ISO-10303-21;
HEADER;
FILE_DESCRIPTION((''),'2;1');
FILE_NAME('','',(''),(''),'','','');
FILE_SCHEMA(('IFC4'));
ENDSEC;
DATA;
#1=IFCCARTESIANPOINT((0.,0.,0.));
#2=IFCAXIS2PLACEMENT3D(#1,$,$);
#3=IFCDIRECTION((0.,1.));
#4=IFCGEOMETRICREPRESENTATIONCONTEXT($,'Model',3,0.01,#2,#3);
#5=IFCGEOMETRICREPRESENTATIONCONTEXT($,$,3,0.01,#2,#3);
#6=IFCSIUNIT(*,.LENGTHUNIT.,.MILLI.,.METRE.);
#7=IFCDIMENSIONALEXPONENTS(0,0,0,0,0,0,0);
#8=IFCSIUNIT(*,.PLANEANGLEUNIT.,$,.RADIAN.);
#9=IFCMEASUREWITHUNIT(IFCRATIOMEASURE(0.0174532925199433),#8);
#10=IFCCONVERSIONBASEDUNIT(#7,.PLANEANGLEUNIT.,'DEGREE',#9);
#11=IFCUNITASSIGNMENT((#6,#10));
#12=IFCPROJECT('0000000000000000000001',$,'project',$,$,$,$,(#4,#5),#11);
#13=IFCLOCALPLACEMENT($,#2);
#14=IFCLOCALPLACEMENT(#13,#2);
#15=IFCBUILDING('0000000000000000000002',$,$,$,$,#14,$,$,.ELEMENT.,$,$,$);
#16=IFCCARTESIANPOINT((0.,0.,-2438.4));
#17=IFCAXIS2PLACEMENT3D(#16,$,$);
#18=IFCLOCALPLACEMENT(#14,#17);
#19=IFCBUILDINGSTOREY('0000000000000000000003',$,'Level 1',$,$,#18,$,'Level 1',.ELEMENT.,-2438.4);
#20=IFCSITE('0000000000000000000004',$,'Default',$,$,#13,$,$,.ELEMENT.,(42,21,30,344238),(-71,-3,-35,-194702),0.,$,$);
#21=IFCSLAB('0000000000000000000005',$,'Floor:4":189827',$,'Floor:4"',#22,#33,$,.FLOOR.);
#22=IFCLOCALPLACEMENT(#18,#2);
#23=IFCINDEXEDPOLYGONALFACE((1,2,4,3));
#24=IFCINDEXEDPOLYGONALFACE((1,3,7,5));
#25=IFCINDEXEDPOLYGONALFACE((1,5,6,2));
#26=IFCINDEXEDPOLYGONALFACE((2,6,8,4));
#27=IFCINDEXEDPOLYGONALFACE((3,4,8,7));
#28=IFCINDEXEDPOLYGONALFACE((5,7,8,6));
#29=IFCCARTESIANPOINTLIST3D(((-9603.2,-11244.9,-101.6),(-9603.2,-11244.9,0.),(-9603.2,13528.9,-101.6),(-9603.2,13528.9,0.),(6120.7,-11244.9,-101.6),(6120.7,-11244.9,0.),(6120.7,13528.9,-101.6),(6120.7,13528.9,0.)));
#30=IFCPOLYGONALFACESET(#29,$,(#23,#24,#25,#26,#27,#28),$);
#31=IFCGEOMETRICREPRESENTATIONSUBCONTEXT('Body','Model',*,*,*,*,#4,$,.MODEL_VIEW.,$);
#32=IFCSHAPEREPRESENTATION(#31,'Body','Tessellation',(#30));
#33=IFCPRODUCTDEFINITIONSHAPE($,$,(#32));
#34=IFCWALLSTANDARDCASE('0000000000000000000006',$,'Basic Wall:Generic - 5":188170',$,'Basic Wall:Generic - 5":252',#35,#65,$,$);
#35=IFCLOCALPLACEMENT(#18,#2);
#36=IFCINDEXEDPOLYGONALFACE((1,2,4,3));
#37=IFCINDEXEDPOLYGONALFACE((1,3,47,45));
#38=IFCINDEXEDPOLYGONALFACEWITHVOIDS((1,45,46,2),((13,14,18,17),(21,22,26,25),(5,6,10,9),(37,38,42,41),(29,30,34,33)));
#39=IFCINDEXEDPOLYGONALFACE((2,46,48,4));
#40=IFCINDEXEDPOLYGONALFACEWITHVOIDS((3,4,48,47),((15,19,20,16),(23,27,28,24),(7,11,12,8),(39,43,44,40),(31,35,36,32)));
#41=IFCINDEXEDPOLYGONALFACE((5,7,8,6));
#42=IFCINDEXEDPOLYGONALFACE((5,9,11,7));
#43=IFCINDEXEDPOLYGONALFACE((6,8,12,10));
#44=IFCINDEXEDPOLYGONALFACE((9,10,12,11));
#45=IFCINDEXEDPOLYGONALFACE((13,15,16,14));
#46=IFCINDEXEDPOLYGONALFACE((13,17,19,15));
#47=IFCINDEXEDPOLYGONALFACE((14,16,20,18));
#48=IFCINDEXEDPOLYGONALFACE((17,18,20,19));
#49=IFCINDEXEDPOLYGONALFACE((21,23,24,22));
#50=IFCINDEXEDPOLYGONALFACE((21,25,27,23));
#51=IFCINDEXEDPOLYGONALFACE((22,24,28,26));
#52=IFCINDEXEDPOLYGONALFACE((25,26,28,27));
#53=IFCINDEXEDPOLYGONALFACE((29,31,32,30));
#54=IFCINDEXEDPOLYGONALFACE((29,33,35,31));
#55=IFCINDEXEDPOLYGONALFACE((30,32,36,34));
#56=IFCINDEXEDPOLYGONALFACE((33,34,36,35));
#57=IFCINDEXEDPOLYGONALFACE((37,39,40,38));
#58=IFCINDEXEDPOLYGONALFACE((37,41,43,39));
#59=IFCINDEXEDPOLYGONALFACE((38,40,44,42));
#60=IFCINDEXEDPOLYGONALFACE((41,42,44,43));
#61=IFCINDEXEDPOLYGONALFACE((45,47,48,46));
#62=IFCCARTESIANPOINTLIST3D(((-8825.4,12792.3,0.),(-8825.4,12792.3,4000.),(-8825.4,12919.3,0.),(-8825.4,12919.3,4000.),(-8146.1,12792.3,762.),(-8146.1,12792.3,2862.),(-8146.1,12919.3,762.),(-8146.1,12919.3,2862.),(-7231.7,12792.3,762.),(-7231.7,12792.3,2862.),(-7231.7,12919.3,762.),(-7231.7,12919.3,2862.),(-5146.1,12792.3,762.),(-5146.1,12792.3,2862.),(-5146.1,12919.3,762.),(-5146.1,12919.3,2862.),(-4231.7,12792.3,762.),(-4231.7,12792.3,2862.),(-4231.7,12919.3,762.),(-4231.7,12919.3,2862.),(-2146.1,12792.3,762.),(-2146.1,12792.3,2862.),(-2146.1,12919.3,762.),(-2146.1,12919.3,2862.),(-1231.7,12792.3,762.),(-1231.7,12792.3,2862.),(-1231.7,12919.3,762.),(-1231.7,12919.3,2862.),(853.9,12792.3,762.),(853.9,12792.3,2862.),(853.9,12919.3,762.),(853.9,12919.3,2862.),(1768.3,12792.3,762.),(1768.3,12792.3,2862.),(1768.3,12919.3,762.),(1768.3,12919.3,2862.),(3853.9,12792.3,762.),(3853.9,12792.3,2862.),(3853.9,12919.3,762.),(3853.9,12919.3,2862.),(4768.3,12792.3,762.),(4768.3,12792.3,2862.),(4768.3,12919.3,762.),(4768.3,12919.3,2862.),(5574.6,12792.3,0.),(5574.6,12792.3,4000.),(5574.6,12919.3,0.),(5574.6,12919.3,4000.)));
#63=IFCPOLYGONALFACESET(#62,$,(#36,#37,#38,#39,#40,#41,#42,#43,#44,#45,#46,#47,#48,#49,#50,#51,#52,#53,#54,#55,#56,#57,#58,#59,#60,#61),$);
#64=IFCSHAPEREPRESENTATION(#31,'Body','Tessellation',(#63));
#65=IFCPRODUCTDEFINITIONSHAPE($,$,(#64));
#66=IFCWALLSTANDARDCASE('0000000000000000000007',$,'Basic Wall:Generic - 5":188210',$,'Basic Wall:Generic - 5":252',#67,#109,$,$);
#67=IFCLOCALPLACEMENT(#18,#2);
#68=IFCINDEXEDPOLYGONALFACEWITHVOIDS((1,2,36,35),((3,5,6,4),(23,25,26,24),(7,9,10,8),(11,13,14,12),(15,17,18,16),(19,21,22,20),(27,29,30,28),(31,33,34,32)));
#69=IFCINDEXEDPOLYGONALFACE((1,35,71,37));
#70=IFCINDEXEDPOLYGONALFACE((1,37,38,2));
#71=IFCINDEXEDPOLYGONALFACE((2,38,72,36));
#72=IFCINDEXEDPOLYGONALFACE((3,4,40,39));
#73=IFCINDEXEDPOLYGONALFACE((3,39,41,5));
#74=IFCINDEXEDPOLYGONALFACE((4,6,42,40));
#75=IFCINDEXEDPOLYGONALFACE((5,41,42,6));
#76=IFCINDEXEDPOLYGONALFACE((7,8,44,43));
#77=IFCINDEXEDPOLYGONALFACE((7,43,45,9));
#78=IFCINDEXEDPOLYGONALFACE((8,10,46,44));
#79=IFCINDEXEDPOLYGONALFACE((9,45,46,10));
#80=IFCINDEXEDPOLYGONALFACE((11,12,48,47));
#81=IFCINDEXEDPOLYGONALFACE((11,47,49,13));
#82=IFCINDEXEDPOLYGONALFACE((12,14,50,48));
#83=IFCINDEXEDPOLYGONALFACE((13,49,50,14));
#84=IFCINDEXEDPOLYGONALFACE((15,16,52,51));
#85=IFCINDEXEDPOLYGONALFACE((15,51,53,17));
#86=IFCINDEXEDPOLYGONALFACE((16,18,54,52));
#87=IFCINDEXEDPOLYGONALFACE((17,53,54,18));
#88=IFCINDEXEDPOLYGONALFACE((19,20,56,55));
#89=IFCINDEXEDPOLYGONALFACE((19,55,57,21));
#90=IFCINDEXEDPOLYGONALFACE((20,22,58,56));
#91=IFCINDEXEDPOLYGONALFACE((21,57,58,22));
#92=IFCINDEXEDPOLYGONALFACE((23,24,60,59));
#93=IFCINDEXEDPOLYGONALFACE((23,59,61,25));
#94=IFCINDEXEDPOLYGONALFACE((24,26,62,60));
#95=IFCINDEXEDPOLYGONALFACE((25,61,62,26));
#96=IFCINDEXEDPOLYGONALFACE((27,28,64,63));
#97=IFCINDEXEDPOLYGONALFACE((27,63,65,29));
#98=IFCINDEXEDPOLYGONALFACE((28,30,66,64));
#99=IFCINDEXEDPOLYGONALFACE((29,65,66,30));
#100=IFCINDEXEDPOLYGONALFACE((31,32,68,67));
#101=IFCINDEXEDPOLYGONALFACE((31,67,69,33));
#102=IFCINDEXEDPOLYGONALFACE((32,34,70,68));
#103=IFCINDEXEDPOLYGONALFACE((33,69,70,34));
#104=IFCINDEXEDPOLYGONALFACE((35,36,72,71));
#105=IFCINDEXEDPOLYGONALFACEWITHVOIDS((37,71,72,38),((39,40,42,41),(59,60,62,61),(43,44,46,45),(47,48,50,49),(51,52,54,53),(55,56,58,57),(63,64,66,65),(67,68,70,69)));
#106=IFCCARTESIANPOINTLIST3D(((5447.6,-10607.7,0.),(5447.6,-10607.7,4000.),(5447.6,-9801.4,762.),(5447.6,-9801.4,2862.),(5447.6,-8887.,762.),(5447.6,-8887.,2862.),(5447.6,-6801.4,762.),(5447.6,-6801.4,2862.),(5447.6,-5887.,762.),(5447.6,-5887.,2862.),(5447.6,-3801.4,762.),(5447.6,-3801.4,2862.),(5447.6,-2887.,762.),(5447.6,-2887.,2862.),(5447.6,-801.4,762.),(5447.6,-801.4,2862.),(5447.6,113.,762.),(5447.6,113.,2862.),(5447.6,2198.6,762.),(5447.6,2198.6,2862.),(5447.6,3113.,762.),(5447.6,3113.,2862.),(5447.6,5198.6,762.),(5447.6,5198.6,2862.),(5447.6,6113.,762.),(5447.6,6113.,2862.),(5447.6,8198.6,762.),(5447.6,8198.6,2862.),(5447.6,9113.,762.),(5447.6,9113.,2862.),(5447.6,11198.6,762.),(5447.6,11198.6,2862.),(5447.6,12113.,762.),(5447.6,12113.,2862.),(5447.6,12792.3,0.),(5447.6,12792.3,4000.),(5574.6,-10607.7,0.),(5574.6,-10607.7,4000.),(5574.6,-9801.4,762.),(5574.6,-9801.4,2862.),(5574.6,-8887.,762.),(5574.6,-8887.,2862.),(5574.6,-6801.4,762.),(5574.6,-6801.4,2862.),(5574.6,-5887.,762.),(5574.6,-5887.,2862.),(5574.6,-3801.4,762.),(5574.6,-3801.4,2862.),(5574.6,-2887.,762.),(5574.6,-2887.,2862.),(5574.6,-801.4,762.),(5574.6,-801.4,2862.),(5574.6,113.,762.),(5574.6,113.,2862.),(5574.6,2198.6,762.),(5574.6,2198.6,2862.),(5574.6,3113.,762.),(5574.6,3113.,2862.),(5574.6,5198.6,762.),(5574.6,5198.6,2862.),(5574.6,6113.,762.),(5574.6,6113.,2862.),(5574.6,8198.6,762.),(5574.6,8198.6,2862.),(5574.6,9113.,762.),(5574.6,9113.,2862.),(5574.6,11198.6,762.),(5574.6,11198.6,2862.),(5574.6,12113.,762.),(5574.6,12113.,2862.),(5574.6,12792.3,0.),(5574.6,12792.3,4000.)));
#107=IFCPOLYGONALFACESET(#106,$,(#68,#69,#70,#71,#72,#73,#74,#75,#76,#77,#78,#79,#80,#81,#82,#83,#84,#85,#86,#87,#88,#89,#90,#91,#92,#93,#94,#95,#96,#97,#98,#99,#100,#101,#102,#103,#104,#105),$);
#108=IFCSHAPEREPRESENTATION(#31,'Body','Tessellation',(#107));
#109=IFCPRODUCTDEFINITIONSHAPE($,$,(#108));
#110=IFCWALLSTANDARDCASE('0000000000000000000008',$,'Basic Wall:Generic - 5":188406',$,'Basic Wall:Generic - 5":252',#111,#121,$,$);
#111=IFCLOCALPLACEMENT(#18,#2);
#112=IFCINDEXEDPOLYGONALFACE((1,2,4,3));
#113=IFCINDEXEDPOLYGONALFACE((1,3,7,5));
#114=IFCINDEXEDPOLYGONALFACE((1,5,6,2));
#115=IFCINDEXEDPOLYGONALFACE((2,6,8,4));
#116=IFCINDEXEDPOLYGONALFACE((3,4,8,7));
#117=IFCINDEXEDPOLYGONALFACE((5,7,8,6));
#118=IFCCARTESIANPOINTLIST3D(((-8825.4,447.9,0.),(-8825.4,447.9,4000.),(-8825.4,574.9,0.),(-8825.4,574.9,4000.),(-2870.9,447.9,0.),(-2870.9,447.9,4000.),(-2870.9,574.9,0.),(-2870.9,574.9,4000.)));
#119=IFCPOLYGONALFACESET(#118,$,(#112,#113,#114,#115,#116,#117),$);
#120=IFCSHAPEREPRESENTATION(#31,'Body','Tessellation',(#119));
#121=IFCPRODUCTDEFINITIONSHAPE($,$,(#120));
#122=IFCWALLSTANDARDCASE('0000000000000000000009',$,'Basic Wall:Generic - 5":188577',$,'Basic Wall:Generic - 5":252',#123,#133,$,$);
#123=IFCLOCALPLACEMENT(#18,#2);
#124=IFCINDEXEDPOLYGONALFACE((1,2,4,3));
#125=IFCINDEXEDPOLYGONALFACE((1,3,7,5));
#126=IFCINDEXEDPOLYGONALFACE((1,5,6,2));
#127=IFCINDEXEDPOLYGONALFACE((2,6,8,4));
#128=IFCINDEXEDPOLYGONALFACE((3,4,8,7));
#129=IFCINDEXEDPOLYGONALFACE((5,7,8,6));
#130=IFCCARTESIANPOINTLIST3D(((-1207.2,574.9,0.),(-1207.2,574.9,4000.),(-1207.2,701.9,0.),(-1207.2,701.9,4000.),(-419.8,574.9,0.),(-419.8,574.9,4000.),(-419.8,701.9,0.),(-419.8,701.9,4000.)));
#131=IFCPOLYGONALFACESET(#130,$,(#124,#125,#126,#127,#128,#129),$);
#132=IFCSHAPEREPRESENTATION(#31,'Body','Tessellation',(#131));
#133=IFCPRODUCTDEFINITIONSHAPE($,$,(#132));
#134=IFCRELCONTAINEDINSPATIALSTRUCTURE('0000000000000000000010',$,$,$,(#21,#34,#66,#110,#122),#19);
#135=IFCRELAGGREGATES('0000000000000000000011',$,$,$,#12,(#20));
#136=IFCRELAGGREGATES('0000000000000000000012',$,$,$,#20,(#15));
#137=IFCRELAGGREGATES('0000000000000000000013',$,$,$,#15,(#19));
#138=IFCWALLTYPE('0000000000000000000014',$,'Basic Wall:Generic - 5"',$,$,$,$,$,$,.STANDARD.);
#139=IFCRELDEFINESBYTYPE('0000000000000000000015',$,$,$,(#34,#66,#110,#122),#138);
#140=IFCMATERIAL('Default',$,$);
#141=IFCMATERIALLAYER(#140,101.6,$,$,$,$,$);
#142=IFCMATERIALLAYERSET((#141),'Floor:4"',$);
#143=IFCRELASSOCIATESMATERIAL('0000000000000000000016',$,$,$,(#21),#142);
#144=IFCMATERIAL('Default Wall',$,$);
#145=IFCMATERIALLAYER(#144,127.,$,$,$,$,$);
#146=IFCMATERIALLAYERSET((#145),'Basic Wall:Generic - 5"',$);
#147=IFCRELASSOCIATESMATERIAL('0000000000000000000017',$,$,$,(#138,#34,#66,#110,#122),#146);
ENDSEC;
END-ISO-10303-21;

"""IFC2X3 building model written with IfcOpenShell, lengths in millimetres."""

from ifc_helpers import new_model, entity, si_unit, converted_unit, direction, frame, frame_2d, origin, place, context, subcontext, project, spatial, polyline, rectangle, extrude, clip, bounded_halfspace, material, layer, layer_set, layer_usage, type_object, element, save


model = new_model("IFC2X3")

# Units and contexts
model_context = context("Model", 3, precision=0.01, world=origin(), true_north=direction((0.0, 1.0)))
context_of_model = context(None, 3, precision=0.01, world=origin(), true_north=direction((0.0, 1.0)))
body_context = subcontext(model_context, "Body", "Model", "MODEL_VIEW")
ifc_project = project(units=[si_unit("LENGTHUNIT", "METRE", prefix="MILLI"), converted_unit("PLANEANGLEUNIT", "DEGREE", entity("IfcRatioMeasure", 0.0174532925199433), si_unit("PLANEANGLEUNIT", "RADIAN"), dimensions=[0, 0, 0, 0, 0, 0, 0])], contexts=[model_context, context_of_model])

# Site, building, storey
site_placement = place(None, origin())
site = spatial("IfcSite", under=ifc_project, at=site_placement, Name="Default", CompositionType="ELEMENT", RefLatitude=(42, 21, 30, 344238), RefLongitude=(-71, -3, -35, -194702), RefElevation=0.0)
building_placement = place(site_placement, origin())
building = spatial("IfcBuilding", under=site, at=building_placement, CompositionType="ELEMENT")
storey_placement = place(building_placement, frame((0.0, 0.0, -2438.4)))
storey = spatial("IfcBuildingStorey", under=building, at=storey_placement, Name="Level 1", LongName="Level 1", CompositionType="ELEMENT", Elevation=-2438.4)

# Slab
ifc_material_1 = material(Name="Default")
ifc_layer_1 = layer(ifc_material_1, 101.6)
ifc_layer_set_1 = layer_set([ifc_layer_1], Name="Floor:4\"")
ifc_layer_usage_1 = layer_usage(ifc_layer_set_1, "AXIS3", "POSITIVE", 0.0)
slab_placement = place(storey_placement, origin())
element("IfcSlab", 1, at=slab_placement, inside=storey, material=ifc_layer_usage_1, Name="Floor:4\":189827", ObjectType="Floor:4\"", PredefinedType="FLOOR", context=body_context, shape_type="SweptSolid", body=[
    extrude(rectangle(XDim=24773.8, YDim=15723.9, at=frame_2d((0.0, 0.0), x_axis=(1.0, 0.0))), frame((-1741.3, 1142.0, 0.0), z_axis=(0.0, 0.0, -1.0), x_axis=(0.0, 1.0, 0.0)), (0.0, 0.0, 1.0), 101.6),
])

# Walls, openings
ifc_material_2 = material(Name="Default Wall")
ifc_layer_2 = layer(ifc_material_2, 127.0)
ifc_layer_set_2 = layer_set([ifc_layer_2], Name="Basic Wall:Generic - 5\"")
ifc_layer_usage_2 = layer_usage(ifc_layer_set_2, "AXIS2", "NEGATIVE", 63.5)
wall_type = type_object("IfcWallType", Name="Basic Wall:Generic - 5\"", PredefinedType="STANDARD", material=ifc_layer_set_2)
wall_1_placement = place(storey_placement, frame((-8825.4, 12855.8, 0.0)))
wall_1 = element("IfcWallStandardCase", 2, at=wall_1_placement, inside=storey, type_object=wall_type, material=ifc_layer_usage_2, Name="Basic Wall:Generic - 5\":188170", ObjectType="Basic Wall:Generic - 5\":252", context=body_context, shape_type="Clipping", body=[
    clip(extrude(rectangle(XDim=14400.0, YDim=127.0, at=frame_2d((7200.0, 0.0), x_axis=(-1.0, 0.0))), origin(), (0.0, 0.0, 1.0), 4000.0), bounded_halfspace(frame((0.0, -63.5, 4000.0), z_axis=(0.0, 0.0, -1.0), x_axis=(0.0, -1.0, 0.0)), True, frame((0.0, -63.5, 4000.0)), polyline([(0.0, 0.0), (14273.0, 0.0), (14400.0, 0.0), (14400.0, 127.0), (0.0, 127.0), (0.0, 0.0)]))),
])
opening_1_placement = place(wall_1_placement, frame((679.3, -63.5, 762.0)))
element("IfcOpeningElement", 3, at=opening_1_placement, cuts=wall_1, ObjectType="Opening", context=body_context, shape_type="SweptSolid", body=[
    extrude(rectangle(XDim=2100.0, YDim=914.4, at=frame_2d((1050.0, 457.2), x_axis=(-1.0, 0.0))), frame((0.0, 0.0, 0.0), z_axis=(0.0, 1.0, 0.0), x_axis=(0.0, 0.0, 1.0)), (0.0, 0.0, 1.0), 127.0),
])
opening_2_placement = place(wall_1_placement, frame((12679.3, -63.5, 762.0)))
element("IfcOpeningElement", 4, at=opening_2_placement, cuts=wall_1, ObjectType="Opening", context=body_context, shape_type="SweptSolid", body=[
    extrude(rectangle(XDim=2100.0, YDim=914.4, at=frame_2d((1050.0, 457.2), x_axis=(-1.0, 0.0))), frame((0.0, 0.0, 0.0), z_axis=(0.0, 1.0, 0.0), x_axis=(0.0, 0.0, 1.0)), (0.0, 0.0, 1.0), 127.0),
])
opening_3_placement = place(wall_1_placement, frame((10593.7, 63.5, 762.0)))
element("IfcOpeningElement", 5, at=opening_3_placement, cuts=wall_1, ObjectType="Opening", context=body_context, shape_type="SweptSolid", body=[
    extrude(rectangle(XDim=2100.0, YDim=914.4, at=frame_2d((1050.0, 457.2), x_axis=(-1.0, 0.0))), frame((0.0, 0.0, 0.0), z_axis=(0.0, -1.0, 0.0), x_axis=(0.0, 0.0, 1.0)), (0.0, 0.0, 1.0), 127.0),
])
opening_4_placement = place(wall_1_placement, frame((7593.7, 63.5, 762.0)))
element("IfcOpeningElement", 6, at=opening_4_placement, cuts=wall_1, ObjectType="Opening", context=body_context, shape_type="SweptSolid", body=[
    extrude(rectangle(XDim=2100.0, YDim=914.4, at=frame_2d((1050.0, 457.2), x_axis=(-1.0, 0.0))), frame((0.0, 0.0, 0.0), z_axis=(0.0, -1.0, 0.0), x_axis=(0.0, 0.0, 1.0)), (0.0, 0.0, 1.0), 127.0),
])
opening_5_placement = place(wall_1_placement, frame((3679.3, -63.5, 762.0)))
element("IfcOpeningElement", 7, at=opening_5_placement, cuts=wall_1, ObjectType="Opening", context=body_context, shape_type="SweptSolid", body=[
    extrude(rectangle(XDim=2100.0, YDim=914.4, at=frame_2d((1050.0, 457.2), x_axis=(-1.0, 0.0))), frame((0.0, 0.0, 0.0), z_axis=(0.0, 1.0, 0.0), x_axis=(0.0, 0.0, 1.0)), (0.0, 0.0, 1.0), 127.0),
])
ifc_layer_usage_3 = layer_usage(ifc_layer_set_2, "AXIS2", "NEGATIVE", 63.5)
wall_2_placement = place(storey_placement, frame((5511.1, 12792.3, 0.0), z_axis=(0.0, 0.0, 1.0), x_axis=(0.0, -1.0, 0.0)))
wall_2 = element("IfcWallStandardCase", 8, at=wall_2_placement, inside=storey, type_object=wall_type, material=ifc_layer_usage_3, Name="Basic Wall:Generic - 5\":188210", ObjectType="Basic Wall:Generic - 5\":252", context=body_context, shape_type="Clipping", body=[
    clip(extrude(rectangle(XDim=23400.0, YDim=127.0, at=frame_2d((11700.0, 0.0), x_axis=(-1.0, 0.0))), origin(), (0.0, 0.0, 1.0), 4000.0), bounded_halfspace(frame((0.0, 63.5, 4000.0), z_axis=(0.0, 0.0, -1.0), x_axis=(1.0, 0.0, 0.0)), True, frame((0.0, 63.5, 4000.0)), polyline([(0.0, 0.0), (0.0, -127.0), (12090.4, -127.0), (12217.4, -127.0), (14351.0, -127.0), (14478.0, -127.0), (20777.2, -127.0), (20904.2, -127.0), (23273.0, -127.0), (23400.0, -127.0), (23400.0, 0.0), (12090.4, 0.0), (8991.6, 0.0), (0.0, 0.0)]))),
])
opening_6_placement = place(wall_2_placement, frame((1593.7, 63.5, 762.0)))
element("IfcOpeningElement", 9, at=opening_6_placement, cuts=wall_2, ObjectType="Opening", context=body_context, shape_type="SweptSolid", body=[
    extrude(rectangle(XDim=2100.0, YDim=914.4, at=frame_2d((1050.0, 457.2), x_axis=(-1.0, 0.0))), frame((0.0, 0.0, 0.0), z_axis=(0.0, -1.0, 0.0), x_axis=(0.0, 0.0, 1.0)), (0.0, 0.0, 1.0), 127.0),
])
opening_7_placement = place(wall_2_placement, frame((4593.7, 63.5, 762.0)))
element("IfcOpeningElement", 10, at=opening_7_placement, cuts=wall_2, ObjectType="Opening", context=body_context, shape_type="SweptSolid", body=[
    extrude(rectangle(XDim=2100.0, YDim=914.4, at=frame_2d((1050.0, 457.2), x_axis=(-1.0, 0.0))), frame((0.0, 0.0, 0.0), z_axis=(0.0, -1.0, 0.0), x_axis=(0.0, 0.0, 1.0)), (0.0, 0.0, 1.0), 127.0),
])
opening_8_placement = place(wall_2_placement, frame((7593.7, 63.5, 762.0)))
element("IfcOpeningElement", 11, at=opening_8_placement, cuts=wall_2, ObjectType="Opening", context=body_context, shape_type="SweptSolid", body=[
    extrude(rectangle(XDim=2100.0, YDim=914.4, at=frame_2d((1050.0, 457.2), x_axis=(-1.0, 0.0))), frame((0.0, 0.0, 0.0), z_axis=(0.0, -1.0, 0.0), x_axis=(0.0, 0.0, 1.0)), (0.0, 0.0, 1.0), 127.0),
])
opening_9_placement = place(wall_2_placement, frame((19593.7, 63.5, 762.0)))
element("IfcOpeningElement", 12, at=opening_9_placement, cuts=wall_2, ObjectType="Opening", context=body_context, shape_type="SweptSolid", body=[
    extrude(rectangle(XDim=2100.0, YDim=914.4, at=frame_2d((1050.0, 457.2), x_axis=(-1.0, 0.0))), frame((0.0, 0.0, 0.0), z_axis=(0.0, -1.0, 0.0), x_axis=(0.0, 0.0, 1.0)), (0.0, 0.0, 1.0), 127.0),
])
opening_10_placement = place(wall_2_placement, frame((16593.7, 63.5, 762.0)))
element("IfcOpeningElement", 13, at=opening_10_placement, cuts=wall_2, ObjectType="Opening", context=body_context, shape_type="SweptSolid", body=[
    extrude(rectangle(XDim=2100.0, YDim=914.4, at=frame_2d((1050.0, 457.2), x_axis=(-1.0, 0.0))), frame((0.0, 0.0, 0.0), z_axis=(0.0, -1.0, 0.0), x_axis=(0.0, 0.0, 1.0)), (0.0, 0.0, 1.0), 127.0),
])
opening_11_placement = place(wall_2_placement, frame((13593.7, 63.5, 762.0)))
element("IfcOpeningElement", 14, at=opening_11_placement, cuts=wall_2, ObjectType="Opening", context=body_context, shape_type="SweptSolid", body=[
    extrude(rectangle(XDim=2100.0, YDim=914.4, at=frame_2d((1050.0, 457.2), x_axis=(-1.0, 0.0))), frame((0.0, 0.0, 0.0), z_axis=(0.0, -1.0, 0.0), x_axis=(0.0, 0.0, 1.0)), (0.0, 0.0, 1.0), 127.0),
])
opening_12_placement = place(wall_2_placement, frame((10593.7, 63.5, 762.0)))
element("IfcOpeningElement", 15, at=opening_12_placement, cuts=wall_2, ObjectType="Opening", context=body_context, shape_type="SweptSolid", body=[
    extrude(rectangle(XDim=2100.0, YDim=914.4, at=frame_2d((1050.0, 457.2), x_axis=(-1.0, 0.0))), frame((0.0, 0.0, 0.0), z_axis=(0.0, -1.0, 0.0), x_axis=(0.0, 0.0, 1.0)), (0.0, 0.0, 1.0), 127.0),
])
opening_13_placement = place(wall_2_placement, frame((22593.7, 63.5, 762.0)))
element("IfcOpeningElement", 16, at=opening_13_placement, cuts=wall_2, ObjectType="Opening", context=body_context, shape_type="SweptSolid", body=[
    extrude(rectangle(XDim=2100.0, YDim=914.4, at=frame_2d((1050.0, 457.2), x_axis=(-1.0, 0.0))), frame((0.0, 0.0, 0.0), z_axis=(0.0, -1.0, 0.0), x_axis=(0.0, 0.0, 1.0)), (0.0, 0.0, 1.0), 127.0),
])

# Walls
ifc_layer_usage_4 = layer_usage(ifc_layer_set_2, "AXIS2", "POSITIVE", -63.5)
wall_3_placement = place(storey_placement, frame((-8825.4, 511.4, 0.0)))
element("IfcWallStandardCase", 17, at=wall_3_placement, inside=storey, type_object=wall_type, material=ifc_layer_usage_4, Name="Basic Wall:Generic - 5\":188406", ObjectType="Basic Wall:Generic - 5\":252", context=body_context, shape_type="Clipping", body=[
    clip(extrude(rectangle(XDim=5954.5, YDim=127.0, at=frame_2d((2977.3, 0.0), x_axis=(-1.0, 0.0))), origin(), (0.0, 0.0, 1.0), 4000.0), bounded_halfspace(frame((0.0, -63.5, 4000.0), z_axis=(0.0, 0.0, -1.0), x_axis=(0.0, -1.0, 0.0)), True, frame((0.0, -63.5, 4000.0)), polyline([(0.0, 0.0), (5954.5, 0.0), (5954.5, 127.0), (0.0, 127.0), (0.0, 0.0)]))),
])
ifc_layer_usage_5 = layer_usage(ifc_layer_set_2, "AXIS2", "NEGATIVE", 63.5)
wall_4_placement = place(storey_placement, frame((-1207.2, 638.4, 0.0)))
element("IfcWallStandardCase", 18, at=wall_4_placement, inside=storey, type_object=wall_type, material=ifc_layer_usage_5, Name="Basic Wall:Generic - 5\":188577", ObjectType="Basic Wall:Generic - 5\":252", context=body_context, shape_type="Clipping", body=[
    clip(extrude(rectangle(XDim=787.4, YDim=127.0, at=frame_2d((393.7, 0.0), x_axis=(-1.0, 0.0))), origin(), (0.0, 0.0, 1.0), 4000.0), bounded_halfspace(frame((0.0, -63.5, 4000.0), z_axis=(0.0, 0.0, -1.0), x_axis=(0.0, -1.0, 0.0)), True, frame((0.0, -63.5, 4000.0)), polyline([(0.0, 0.0), (787.4, 0.0), (787.4, 127.0), (0.0, 127.0), (0.0, 0.0)]))),
])

save(model, "model.ifc")
